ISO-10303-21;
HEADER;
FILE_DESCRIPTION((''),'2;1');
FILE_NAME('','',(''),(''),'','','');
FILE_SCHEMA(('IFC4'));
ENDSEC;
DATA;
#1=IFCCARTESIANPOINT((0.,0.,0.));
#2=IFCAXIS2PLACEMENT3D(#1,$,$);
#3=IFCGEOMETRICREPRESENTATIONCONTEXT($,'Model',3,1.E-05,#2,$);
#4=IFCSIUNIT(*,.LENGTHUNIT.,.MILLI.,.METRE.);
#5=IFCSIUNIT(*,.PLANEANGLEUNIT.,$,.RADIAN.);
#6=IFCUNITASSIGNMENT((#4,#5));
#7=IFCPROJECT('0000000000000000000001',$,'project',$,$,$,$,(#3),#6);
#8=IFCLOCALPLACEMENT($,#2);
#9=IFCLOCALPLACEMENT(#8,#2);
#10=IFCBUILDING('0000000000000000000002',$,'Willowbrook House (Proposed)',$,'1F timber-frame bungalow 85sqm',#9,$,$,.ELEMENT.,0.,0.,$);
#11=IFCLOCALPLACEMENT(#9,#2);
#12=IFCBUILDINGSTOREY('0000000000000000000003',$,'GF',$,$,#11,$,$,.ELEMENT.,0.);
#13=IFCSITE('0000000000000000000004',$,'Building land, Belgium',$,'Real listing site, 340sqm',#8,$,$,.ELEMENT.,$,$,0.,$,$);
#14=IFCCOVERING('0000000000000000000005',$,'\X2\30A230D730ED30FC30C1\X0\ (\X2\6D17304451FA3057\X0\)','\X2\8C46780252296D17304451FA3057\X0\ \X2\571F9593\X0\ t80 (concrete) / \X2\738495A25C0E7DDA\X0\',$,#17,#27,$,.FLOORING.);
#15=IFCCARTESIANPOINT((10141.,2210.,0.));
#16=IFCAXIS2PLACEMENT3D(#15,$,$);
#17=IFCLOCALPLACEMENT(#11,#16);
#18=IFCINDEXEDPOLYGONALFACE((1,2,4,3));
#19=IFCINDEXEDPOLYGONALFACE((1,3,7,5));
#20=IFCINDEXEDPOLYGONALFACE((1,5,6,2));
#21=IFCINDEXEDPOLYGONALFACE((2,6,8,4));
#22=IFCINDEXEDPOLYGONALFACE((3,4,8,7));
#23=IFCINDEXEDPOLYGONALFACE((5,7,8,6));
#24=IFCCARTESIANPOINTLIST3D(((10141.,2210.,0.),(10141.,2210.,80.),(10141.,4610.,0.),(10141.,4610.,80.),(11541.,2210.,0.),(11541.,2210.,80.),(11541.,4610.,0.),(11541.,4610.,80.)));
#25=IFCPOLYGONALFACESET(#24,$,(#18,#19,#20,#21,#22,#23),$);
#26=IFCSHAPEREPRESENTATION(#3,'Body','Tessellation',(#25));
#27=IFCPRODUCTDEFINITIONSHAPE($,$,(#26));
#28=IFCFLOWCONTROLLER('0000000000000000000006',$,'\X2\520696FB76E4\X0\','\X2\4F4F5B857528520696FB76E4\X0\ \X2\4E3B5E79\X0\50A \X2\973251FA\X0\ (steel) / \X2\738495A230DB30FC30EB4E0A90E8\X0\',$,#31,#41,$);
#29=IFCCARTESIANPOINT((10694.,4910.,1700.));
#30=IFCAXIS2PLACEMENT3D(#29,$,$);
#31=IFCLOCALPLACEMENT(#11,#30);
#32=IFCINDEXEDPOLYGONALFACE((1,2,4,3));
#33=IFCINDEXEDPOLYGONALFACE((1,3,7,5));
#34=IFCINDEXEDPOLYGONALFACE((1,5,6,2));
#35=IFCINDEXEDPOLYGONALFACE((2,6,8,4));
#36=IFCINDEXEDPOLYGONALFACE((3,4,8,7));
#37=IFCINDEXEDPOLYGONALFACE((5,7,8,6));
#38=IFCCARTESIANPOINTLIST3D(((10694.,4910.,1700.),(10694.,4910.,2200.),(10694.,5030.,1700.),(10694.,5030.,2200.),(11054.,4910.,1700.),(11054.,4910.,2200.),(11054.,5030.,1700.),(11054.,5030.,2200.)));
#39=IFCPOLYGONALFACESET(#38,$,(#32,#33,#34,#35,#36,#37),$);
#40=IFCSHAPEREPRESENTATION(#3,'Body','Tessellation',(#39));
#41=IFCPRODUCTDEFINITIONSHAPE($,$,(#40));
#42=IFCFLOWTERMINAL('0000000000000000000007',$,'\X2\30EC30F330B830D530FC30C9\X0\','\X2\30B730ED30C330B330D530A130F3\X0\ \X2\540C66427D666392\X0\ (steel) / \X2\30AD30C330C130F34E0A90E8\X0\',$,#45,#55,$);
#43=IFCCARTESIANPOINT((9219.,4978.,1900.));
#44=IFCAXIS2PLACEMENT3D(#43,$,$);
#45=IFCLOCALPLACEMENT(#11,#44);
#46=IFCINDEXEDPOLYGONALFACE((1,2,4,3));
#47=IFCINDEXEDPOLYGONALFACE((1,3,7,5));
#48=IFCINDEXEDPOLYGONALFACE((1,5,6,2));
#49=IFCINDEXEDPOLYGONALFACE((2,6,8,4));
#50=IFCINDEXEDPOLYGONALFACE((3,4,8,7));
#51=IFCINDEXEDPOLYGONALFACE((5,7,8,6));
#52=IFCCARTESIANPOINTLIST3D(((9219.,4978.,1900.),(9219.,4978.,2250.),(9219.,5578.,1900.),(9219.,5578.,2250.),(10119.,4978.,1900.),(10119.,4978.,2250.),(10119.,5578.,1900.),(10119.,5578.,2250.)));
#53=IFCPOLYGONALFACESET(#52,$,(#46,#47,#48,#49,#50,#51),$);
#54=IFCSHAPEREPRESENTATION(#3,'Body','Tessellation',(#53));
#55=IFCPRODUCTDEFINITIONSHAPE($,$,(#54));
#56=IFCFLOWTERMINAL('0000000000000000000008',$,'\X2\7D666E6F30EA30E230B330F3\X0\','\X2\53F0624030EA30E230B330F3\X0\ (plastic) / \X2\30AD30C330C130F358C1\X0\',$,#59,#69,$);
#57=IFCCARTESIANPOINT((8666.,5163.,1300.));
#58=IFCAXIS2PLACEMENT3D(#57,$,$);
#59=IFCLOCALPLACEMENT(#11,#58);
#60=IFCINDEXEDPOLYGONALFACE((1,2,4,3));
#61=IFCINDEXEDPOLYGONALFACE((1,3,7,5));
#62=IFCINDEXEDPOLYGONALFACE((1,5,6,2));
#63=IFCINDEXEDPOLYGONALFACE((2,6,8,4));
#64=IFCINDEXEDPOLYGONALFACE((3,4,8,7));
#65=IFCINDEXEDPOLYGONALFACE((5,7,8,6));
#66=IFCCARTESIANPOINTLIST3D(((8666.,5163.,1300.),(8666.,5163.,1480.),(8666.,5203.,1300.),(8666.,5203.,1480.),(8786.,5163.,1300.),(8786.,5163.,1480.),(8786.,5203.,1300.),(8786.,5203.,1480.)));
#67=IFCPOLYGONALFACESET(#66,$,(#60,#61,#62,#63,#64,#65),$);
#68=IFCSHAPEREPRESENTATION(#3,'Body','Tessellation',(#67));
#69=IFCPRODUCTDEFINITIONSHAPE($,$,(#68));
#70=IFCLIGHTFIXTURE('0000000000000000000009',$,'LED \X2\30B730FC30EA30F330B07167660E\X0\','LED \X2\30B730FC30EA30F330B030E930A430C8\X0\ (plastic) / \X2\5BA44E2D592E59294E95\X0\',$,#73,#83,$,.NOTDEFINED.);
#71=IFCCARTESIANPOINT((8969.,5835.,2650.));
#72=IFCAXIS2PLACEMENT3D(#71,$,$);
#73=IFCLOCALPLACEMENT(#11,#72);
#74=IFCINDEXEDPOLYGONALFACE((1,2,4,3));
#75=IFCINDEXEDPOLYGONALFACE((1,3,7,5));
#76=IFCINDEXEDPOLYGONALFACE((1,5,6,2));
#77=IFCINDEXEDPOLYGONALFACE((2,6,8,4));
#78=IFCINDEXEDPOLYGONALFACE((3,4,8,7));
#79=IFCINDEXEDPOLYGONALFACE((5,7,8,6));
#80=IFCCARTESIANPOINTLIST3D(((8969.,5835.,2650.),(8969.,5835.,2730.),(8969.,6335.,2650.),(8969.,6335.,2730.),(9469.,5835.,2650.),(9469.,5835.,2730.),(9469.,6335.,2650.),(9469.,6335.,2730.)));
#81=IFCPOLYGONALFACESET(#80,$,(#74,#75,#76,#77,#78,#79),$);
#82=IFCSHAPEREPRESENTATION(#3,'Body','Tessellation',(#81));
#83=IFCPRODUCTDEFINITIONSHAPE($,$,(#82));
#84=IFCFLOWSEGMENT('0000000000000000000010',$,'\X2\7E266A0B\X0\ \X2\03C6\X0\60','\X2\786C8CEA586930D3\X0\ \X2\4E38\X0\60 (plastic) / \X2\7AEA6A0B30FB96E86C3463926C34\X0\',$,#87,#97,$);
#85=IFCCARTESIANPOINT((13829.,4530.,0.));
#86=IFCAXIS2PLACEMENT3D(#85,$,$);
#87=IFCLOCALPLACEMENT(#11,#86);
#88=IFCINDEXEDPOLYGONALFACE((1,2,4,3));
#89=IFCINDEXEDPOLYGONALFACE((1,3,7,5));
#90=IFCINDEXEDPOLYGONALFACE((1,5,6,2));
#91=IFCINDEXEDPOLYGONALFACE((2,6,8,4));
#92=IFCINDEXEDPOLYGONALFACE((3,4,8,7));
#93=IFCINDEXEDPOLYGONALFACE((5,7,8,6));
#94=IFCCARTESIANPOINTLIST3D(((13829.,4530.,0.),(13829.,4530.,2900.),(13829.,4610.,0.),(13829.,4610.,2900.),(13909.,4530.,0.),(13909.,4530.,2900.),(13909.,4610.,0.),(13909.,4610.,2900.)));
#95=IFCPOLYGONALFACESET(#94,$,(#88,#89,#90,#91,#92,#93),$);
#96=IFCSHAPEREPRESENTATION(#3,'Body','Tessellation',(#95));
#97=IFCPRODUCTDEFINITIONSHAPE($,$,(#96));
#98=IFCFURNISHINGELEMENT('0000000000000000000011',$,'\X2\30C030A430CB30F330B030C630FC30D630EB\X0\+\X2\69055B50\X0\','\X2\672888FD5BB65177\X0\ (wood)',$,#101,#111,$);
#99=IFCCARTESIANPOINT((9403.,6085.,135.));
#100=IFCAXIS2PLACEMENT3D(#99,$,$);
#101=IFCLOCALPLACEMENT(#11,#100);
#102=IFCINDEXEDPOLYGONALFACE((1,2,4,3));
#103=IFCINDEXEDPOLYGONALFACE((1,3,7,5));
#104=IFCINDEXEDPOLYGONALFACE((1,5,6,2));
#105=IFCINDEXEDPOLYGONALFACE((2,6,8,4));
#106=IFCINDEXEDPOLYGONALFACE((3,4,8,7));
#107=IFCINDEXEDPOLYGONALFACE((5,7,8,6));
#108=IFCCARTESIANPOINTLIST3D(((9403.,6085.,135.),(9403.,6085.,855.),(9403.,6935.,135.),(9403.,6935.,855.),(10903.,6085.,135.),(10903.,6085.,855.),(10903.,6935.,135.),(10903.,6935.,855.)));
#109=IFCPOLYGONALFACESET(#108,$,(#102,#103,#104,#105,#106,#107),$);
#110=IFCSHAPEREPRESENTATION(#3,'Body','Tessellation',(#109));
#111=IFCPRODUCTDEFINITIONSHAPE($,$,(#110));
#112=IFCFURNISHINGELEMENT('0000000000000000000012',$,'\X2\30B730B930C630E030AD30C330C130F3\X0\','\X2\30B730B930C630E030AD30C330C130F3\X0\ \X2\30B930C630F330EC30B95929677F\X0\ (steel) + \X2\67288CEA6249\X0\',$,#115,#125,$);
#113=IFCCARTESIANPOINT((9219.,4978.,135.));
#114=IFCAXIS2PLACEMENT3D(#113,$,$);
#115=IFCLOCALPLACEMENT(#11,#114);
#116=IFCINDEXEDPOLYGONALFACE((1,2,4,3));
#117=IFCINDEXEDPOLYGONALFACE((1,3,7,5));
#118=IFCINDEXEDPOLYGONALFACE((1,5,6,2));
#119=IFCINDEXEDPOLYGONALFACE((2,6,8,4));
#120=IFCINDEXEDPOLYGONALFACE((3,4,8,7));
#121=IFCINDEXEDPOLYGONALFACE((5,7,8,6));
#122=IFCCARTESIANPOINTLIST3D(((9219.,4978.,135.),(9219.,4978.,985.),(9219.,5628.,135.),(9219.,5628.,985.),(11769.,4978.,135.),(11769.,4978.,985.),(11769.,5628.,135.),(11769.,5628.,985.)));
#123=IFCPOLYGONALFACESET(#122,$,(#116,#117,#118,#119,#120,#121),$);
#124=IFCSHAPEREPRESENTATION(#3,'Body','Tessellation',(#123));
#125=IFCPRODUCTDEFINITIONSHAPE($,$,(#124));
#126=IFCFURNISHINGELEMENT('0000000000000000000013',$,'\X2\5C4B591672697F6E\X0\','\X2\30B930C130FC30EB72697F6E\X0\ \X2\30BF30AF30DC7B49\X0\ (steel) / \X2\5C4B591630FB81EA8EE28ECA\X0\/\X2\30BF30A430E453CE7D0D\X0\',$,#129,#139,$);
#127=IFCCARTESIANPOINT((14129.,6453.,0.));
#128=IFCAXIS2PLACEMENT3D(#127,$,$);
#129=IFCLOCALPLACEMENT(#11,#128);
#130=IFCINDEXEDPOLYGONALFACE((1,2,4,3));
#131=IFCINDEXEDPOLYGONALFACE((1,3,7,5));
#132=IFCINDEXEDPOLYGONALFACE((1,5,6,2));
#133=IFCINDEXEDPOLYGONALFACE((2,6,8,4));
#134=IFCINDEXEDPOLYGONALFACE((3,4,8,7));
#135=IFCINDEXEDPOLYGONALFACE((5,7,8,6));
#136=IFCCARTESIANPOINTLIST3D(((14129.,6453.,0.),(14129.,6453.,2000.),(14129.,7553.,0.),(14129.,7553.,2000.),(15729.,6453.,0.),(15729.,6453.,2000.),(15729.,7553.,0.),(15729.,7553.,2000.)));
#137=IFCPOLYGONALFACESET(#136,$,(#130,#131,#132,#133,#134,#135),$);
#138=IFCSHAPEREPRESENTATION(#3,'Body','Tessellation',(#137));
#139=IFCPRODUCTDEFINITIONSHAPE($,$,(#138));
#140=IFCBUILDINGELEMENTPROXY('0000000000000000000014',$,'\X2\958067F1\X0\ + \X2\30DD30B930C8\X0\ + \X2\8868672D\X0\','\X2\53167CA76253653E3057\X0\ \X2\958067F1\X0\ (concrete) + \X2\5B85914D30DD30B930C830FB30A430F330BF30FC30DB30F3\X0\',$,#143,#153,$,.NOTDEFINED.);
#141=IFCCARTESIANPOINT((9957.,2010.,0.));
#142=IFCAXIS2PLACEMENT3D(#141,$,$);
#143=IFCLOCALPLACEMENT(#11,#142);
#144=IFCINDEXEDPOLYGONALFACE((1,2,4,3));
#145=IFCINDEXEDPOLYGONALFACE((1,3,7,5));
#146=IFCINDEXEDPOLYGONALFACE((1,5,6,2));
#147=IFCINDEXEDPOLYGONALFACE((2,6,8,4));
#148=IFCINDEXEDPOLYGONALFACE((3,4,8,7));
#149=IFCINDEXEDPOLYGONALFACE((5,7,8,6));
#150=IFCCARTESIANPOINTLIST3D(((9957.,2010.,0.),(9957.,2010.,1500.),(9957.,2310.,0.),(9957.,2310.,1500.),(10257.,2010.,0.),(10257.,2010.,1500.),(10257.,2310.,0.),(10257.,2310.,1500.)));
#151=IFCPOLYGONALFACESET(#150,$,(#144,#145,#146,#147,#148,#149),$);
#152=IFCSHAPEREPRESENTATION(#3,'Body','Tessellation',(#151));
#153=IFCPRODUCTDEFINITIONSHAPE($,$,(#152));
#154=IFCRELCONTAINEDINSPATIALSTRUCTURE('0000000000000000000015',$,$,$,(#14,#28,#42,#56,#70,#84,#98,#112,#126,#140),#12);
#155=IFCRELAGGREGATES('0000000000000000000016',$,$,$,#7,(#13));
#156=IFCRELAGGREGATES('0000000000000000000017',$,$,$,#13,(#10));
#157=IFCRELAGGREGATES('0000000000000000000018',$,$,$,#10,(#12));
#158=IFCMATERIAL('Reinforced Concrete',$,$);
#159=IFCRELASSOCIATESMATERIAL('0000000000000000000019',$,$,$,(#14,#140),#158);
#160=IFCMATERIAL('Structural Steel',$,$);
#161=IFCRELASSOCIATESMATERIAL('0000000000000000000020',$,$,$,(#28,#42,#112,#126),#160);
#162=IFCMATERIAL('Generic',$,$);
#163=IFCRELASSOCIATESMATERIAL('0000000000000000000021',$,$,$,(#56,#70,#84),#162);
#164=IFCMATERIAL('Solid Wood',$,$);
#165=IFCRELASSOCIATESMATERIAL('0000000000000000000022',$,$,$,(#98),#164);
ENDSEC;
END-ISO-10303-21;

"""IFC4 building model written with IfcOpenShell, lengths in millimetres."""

from ifc_helpers import new_model, si_unit, frame, frame_2d, origin, place, context, project, spatial, rectangle, extrude, material, element, save


model = new_model("IFC4")

# Units and contexts
model_context = context("Model", 3, precision=1e-05, world=origin())
ifc_project = project(units=[si_unit("LENGTHUNIT", "METRE", prefix="MILLI"), si_unit("PLANEANGLEUNIT", "RADIAN")], contexts=[model_context])

# Site, building, storey
site_placement = place(None, origin())
site = spatial("IfcSite", under=ifc_project, at=site_placement, Name="Building land, Belgium", ObjectType="Real listing site, 340sqm", CompositionType="ELEMENT", RefElevation=0.0)
building_placement = place(site_placement, origin())
building = spatial("IfcBuilding", under=site, at=building_placement, Name="Willowbrook House (Proposed)", ObjectType="1F timber-frame bungalow 85sqm", CompositionType="ELEMENT", ElevationOfRefHeight=0.0, ElevationOfTerrain=0.0)
storey_placement = place(building_placement, origin())
storey = spatial("IfcBuildingStorey", under=building, at=storey_placement, Name="GF", CompositionType="ELEMENT", Elevation=0.0)

# Shared definitions
ifc_material_1 = material(Name="Solid Wood")

# Shared definitions
ifc_material_2 = material(Name="Structural Steel")

# Covering
ifc_material_3 = material(Name="Reinforced Concrete")
covering_placement = place(storey_placement, frame((10141.0, 2210.0, 0.0)))
element("IfcCovering", 1, at=covering_placement, inside=storey, material=ifc_material_3, Name="アプローチ (洗い出し)", Description="豆砂利洗い出し 土間 t80 (concrete) / 玄関導線", PredefinedType="FLOORING", context=model_context, shape_type="SweptSolid", body=[
    extrude(rectangle(XDim=1400.0, YDim=2400.0, at=frame_2d((700.0, 1200.0))), frame((10141.0, 2210.0, 0.0)), (0.0, 0.0, 1.0), 80.0),
])

# Flow controller
flow_controller_placement = place(storey_placement, frame((10694.0, 4910.0, 1700.0)))
element("IfcFlowController", 2, at=flow_controller_placement, inside=storey, material=ifc_material_2, Name="分電盤", Description="住宅用分電盤 主幹50A 露出 (steel) / 玄関ホール上部", context=model_context, shape_type="SweptSolid", body=[
    extrude(rectangle(XDim=360.0, YDim=120.0, at=frame_2d((180.0, 60.0))), frame((10694.0, 4910.0, 1700.0)), (0.0, 0.0, 1.0), 500.0),
])

# Flow terminals
flow_terminal_1_placement = place(storey_placement, frame((9219.0, 4978.0, 1900.0)))
element("IfcFlowTerminal", 3, at=flow_terminal_1_placement, inside=storey, material=ifc_material_2, Name="レンジフード", Description="シロッコファン 同時給排 (steel) / キッチン上部", context=model_context, shape_type="SweptSolid", body=[
    extrude(rectangle(XDim=900.0, YDim=600.0, at=frame_2d((450.0, 300.0))), frame((9219.0, 4978.0, 1900.0)), (0.0, 0.0, 1.0), 350.0),
])
ifc_material_4 = material(Name="Generic")
flow_terminal_2_placement = place(storey_placement, frame((8666.0, 5163.0, 1300.0)))
element("IfcFlowTerminal", 4, at=flow_terminal_2_placement, inside=storey, material=ifc_material_4, Name="給湯リモコン", Description="台所リモコン (plastic) / キッチン壁", context=model_context, shape_type="SweptSolid", body=[
    extrude(rectangle(XDim=120.0, YDim=40.0, at=frame_2d((60.0, 20.0))), frame((8666.0, 5163.0, 1300.0)), (0.0, 0.0, 1.0), 180.0),
])

# Light fixture
light_fixture_placement = place(storey_placement, frame((8969.0, 5835.0, 2650.0)))
element("IfcLightFixture", 5, at=light_fixture_placement, inside=storey, material=ifc_material_4, Name="LED シーリング照明", Description="LED シーリングライト (plastic) / 室中央天井", PredefinedType="NOTDEFINED", context=model_context, shape_type="SweptSolid", body=[
    extrude(rectangle(XDim=500.0, YDim=500.0, at=frame_2d((250.0, 250.0))), frame((8969.0, 5835.0, 2650.0)), (0.0, 0.0, 1.0), 80.0),
])

# Flow segment
flow_segment_placement = place(storey_placement, frame((13829.0, 4530.0, 0.0)))
element("IfcFlowSegment", 6, at=flow_segment_placement, inside=storey, material=ifc_material_4, Name="縦樋 φ60", Description="硬質塩ビ 丸60 (plastic) / 竪樋・雨水排水", context=model_context, shape_type="SweptSolid", body=[
    extrude(rectangle(XDim=80.0, YDim=80.0, at=frame_2d((40.0, 40.0))), frame((13829.0, 4530.0, 0.0)), (0.0, 0.0, 1.0), 2900.0),
])

# Furnishing elements
furnishing_1_placement = place(storey_placement, frame((9403.0, 6085.0, 135.0)))
element("IfcFurnishingElement", 7, at=furnishing_1_placement, inside=storey, material=ifc_material_1, Name="ダイニングテーブル+椅子", Description="木製家具 (wood)", context=model_context, shape_type="SweptSolid", body=[
    extrude(rectangle(XDim=1500.0, YDim=850.0, at=frame_2d((750.0, 425.0))), frame((9403.0, 6085.0, 135.0)), (0.0, 0.0, 1.0), 720.0),
])
furnishing_2_placement = place(storey_placement, frame((9219.0, 4978.0, 135.0)))
element("IfcFurnishingElement", 8, at=furnishing_2_placement, inside=storey, material=ifc_material_2, Name="システムキッチン", Description="システムキッチン ステンレス天板 (steel) + 木質扉", context=model_context, shape_type="SweptSolid", body=[
    extrude(rectangle(XDim=2550.0, YDim=650.0, at=frame_2d((1275.0, 325.0))), frame((9219.0, 4978.0, 135.0)), (0.0, 0.0, 1.0), 850.0),
])
furnishing_3_placement = place(storey_placement, frame((14129.0, 6453.0, 0.0)))
element("IfcFurnishingElement", 9, at=furnishing_3_placement, inside=storey, material=ifc_material_2, Name="屋外物置", Description="スチール物置 タクボ等 (steel) / 屋外・自転車/タイヤ収納", context=model_context, shape_type="SweptSolid", body=[
    extrude(rectangle(XDim=1600.0, YDim=1100.0, at=frame_2d((800.0, 550.0))), frame((14129.0, 6453.0, 0.0)), (0.0, 0.0, 1.0), 2000.0),
])

# Building element proxy
proxy_placement = place(storey_placement, frame((9957.0, 2010.0, 0.0)))
element("IfcBuildingElementProxy", 10, at=proxy_placement, inside=storey, material=ifc_material_3, Name="門柱 + ポスト + 表札", Description="化粧打放し 門柱 (concrete) + 宅配ポスト・インターホン", PredefinedType="NOTDEFINED", context=model_context, shape_type="SweptSolid", body=[
    extrude(rectangle(XDim=300.0, YDim=300.0, at=frame_2d((150.0, 150.0))), frame((9957.0, 2010.0, 0.0)), (0.0, 0.0, 1.0), 1500.0),
])

save(model, "model.ifc")
